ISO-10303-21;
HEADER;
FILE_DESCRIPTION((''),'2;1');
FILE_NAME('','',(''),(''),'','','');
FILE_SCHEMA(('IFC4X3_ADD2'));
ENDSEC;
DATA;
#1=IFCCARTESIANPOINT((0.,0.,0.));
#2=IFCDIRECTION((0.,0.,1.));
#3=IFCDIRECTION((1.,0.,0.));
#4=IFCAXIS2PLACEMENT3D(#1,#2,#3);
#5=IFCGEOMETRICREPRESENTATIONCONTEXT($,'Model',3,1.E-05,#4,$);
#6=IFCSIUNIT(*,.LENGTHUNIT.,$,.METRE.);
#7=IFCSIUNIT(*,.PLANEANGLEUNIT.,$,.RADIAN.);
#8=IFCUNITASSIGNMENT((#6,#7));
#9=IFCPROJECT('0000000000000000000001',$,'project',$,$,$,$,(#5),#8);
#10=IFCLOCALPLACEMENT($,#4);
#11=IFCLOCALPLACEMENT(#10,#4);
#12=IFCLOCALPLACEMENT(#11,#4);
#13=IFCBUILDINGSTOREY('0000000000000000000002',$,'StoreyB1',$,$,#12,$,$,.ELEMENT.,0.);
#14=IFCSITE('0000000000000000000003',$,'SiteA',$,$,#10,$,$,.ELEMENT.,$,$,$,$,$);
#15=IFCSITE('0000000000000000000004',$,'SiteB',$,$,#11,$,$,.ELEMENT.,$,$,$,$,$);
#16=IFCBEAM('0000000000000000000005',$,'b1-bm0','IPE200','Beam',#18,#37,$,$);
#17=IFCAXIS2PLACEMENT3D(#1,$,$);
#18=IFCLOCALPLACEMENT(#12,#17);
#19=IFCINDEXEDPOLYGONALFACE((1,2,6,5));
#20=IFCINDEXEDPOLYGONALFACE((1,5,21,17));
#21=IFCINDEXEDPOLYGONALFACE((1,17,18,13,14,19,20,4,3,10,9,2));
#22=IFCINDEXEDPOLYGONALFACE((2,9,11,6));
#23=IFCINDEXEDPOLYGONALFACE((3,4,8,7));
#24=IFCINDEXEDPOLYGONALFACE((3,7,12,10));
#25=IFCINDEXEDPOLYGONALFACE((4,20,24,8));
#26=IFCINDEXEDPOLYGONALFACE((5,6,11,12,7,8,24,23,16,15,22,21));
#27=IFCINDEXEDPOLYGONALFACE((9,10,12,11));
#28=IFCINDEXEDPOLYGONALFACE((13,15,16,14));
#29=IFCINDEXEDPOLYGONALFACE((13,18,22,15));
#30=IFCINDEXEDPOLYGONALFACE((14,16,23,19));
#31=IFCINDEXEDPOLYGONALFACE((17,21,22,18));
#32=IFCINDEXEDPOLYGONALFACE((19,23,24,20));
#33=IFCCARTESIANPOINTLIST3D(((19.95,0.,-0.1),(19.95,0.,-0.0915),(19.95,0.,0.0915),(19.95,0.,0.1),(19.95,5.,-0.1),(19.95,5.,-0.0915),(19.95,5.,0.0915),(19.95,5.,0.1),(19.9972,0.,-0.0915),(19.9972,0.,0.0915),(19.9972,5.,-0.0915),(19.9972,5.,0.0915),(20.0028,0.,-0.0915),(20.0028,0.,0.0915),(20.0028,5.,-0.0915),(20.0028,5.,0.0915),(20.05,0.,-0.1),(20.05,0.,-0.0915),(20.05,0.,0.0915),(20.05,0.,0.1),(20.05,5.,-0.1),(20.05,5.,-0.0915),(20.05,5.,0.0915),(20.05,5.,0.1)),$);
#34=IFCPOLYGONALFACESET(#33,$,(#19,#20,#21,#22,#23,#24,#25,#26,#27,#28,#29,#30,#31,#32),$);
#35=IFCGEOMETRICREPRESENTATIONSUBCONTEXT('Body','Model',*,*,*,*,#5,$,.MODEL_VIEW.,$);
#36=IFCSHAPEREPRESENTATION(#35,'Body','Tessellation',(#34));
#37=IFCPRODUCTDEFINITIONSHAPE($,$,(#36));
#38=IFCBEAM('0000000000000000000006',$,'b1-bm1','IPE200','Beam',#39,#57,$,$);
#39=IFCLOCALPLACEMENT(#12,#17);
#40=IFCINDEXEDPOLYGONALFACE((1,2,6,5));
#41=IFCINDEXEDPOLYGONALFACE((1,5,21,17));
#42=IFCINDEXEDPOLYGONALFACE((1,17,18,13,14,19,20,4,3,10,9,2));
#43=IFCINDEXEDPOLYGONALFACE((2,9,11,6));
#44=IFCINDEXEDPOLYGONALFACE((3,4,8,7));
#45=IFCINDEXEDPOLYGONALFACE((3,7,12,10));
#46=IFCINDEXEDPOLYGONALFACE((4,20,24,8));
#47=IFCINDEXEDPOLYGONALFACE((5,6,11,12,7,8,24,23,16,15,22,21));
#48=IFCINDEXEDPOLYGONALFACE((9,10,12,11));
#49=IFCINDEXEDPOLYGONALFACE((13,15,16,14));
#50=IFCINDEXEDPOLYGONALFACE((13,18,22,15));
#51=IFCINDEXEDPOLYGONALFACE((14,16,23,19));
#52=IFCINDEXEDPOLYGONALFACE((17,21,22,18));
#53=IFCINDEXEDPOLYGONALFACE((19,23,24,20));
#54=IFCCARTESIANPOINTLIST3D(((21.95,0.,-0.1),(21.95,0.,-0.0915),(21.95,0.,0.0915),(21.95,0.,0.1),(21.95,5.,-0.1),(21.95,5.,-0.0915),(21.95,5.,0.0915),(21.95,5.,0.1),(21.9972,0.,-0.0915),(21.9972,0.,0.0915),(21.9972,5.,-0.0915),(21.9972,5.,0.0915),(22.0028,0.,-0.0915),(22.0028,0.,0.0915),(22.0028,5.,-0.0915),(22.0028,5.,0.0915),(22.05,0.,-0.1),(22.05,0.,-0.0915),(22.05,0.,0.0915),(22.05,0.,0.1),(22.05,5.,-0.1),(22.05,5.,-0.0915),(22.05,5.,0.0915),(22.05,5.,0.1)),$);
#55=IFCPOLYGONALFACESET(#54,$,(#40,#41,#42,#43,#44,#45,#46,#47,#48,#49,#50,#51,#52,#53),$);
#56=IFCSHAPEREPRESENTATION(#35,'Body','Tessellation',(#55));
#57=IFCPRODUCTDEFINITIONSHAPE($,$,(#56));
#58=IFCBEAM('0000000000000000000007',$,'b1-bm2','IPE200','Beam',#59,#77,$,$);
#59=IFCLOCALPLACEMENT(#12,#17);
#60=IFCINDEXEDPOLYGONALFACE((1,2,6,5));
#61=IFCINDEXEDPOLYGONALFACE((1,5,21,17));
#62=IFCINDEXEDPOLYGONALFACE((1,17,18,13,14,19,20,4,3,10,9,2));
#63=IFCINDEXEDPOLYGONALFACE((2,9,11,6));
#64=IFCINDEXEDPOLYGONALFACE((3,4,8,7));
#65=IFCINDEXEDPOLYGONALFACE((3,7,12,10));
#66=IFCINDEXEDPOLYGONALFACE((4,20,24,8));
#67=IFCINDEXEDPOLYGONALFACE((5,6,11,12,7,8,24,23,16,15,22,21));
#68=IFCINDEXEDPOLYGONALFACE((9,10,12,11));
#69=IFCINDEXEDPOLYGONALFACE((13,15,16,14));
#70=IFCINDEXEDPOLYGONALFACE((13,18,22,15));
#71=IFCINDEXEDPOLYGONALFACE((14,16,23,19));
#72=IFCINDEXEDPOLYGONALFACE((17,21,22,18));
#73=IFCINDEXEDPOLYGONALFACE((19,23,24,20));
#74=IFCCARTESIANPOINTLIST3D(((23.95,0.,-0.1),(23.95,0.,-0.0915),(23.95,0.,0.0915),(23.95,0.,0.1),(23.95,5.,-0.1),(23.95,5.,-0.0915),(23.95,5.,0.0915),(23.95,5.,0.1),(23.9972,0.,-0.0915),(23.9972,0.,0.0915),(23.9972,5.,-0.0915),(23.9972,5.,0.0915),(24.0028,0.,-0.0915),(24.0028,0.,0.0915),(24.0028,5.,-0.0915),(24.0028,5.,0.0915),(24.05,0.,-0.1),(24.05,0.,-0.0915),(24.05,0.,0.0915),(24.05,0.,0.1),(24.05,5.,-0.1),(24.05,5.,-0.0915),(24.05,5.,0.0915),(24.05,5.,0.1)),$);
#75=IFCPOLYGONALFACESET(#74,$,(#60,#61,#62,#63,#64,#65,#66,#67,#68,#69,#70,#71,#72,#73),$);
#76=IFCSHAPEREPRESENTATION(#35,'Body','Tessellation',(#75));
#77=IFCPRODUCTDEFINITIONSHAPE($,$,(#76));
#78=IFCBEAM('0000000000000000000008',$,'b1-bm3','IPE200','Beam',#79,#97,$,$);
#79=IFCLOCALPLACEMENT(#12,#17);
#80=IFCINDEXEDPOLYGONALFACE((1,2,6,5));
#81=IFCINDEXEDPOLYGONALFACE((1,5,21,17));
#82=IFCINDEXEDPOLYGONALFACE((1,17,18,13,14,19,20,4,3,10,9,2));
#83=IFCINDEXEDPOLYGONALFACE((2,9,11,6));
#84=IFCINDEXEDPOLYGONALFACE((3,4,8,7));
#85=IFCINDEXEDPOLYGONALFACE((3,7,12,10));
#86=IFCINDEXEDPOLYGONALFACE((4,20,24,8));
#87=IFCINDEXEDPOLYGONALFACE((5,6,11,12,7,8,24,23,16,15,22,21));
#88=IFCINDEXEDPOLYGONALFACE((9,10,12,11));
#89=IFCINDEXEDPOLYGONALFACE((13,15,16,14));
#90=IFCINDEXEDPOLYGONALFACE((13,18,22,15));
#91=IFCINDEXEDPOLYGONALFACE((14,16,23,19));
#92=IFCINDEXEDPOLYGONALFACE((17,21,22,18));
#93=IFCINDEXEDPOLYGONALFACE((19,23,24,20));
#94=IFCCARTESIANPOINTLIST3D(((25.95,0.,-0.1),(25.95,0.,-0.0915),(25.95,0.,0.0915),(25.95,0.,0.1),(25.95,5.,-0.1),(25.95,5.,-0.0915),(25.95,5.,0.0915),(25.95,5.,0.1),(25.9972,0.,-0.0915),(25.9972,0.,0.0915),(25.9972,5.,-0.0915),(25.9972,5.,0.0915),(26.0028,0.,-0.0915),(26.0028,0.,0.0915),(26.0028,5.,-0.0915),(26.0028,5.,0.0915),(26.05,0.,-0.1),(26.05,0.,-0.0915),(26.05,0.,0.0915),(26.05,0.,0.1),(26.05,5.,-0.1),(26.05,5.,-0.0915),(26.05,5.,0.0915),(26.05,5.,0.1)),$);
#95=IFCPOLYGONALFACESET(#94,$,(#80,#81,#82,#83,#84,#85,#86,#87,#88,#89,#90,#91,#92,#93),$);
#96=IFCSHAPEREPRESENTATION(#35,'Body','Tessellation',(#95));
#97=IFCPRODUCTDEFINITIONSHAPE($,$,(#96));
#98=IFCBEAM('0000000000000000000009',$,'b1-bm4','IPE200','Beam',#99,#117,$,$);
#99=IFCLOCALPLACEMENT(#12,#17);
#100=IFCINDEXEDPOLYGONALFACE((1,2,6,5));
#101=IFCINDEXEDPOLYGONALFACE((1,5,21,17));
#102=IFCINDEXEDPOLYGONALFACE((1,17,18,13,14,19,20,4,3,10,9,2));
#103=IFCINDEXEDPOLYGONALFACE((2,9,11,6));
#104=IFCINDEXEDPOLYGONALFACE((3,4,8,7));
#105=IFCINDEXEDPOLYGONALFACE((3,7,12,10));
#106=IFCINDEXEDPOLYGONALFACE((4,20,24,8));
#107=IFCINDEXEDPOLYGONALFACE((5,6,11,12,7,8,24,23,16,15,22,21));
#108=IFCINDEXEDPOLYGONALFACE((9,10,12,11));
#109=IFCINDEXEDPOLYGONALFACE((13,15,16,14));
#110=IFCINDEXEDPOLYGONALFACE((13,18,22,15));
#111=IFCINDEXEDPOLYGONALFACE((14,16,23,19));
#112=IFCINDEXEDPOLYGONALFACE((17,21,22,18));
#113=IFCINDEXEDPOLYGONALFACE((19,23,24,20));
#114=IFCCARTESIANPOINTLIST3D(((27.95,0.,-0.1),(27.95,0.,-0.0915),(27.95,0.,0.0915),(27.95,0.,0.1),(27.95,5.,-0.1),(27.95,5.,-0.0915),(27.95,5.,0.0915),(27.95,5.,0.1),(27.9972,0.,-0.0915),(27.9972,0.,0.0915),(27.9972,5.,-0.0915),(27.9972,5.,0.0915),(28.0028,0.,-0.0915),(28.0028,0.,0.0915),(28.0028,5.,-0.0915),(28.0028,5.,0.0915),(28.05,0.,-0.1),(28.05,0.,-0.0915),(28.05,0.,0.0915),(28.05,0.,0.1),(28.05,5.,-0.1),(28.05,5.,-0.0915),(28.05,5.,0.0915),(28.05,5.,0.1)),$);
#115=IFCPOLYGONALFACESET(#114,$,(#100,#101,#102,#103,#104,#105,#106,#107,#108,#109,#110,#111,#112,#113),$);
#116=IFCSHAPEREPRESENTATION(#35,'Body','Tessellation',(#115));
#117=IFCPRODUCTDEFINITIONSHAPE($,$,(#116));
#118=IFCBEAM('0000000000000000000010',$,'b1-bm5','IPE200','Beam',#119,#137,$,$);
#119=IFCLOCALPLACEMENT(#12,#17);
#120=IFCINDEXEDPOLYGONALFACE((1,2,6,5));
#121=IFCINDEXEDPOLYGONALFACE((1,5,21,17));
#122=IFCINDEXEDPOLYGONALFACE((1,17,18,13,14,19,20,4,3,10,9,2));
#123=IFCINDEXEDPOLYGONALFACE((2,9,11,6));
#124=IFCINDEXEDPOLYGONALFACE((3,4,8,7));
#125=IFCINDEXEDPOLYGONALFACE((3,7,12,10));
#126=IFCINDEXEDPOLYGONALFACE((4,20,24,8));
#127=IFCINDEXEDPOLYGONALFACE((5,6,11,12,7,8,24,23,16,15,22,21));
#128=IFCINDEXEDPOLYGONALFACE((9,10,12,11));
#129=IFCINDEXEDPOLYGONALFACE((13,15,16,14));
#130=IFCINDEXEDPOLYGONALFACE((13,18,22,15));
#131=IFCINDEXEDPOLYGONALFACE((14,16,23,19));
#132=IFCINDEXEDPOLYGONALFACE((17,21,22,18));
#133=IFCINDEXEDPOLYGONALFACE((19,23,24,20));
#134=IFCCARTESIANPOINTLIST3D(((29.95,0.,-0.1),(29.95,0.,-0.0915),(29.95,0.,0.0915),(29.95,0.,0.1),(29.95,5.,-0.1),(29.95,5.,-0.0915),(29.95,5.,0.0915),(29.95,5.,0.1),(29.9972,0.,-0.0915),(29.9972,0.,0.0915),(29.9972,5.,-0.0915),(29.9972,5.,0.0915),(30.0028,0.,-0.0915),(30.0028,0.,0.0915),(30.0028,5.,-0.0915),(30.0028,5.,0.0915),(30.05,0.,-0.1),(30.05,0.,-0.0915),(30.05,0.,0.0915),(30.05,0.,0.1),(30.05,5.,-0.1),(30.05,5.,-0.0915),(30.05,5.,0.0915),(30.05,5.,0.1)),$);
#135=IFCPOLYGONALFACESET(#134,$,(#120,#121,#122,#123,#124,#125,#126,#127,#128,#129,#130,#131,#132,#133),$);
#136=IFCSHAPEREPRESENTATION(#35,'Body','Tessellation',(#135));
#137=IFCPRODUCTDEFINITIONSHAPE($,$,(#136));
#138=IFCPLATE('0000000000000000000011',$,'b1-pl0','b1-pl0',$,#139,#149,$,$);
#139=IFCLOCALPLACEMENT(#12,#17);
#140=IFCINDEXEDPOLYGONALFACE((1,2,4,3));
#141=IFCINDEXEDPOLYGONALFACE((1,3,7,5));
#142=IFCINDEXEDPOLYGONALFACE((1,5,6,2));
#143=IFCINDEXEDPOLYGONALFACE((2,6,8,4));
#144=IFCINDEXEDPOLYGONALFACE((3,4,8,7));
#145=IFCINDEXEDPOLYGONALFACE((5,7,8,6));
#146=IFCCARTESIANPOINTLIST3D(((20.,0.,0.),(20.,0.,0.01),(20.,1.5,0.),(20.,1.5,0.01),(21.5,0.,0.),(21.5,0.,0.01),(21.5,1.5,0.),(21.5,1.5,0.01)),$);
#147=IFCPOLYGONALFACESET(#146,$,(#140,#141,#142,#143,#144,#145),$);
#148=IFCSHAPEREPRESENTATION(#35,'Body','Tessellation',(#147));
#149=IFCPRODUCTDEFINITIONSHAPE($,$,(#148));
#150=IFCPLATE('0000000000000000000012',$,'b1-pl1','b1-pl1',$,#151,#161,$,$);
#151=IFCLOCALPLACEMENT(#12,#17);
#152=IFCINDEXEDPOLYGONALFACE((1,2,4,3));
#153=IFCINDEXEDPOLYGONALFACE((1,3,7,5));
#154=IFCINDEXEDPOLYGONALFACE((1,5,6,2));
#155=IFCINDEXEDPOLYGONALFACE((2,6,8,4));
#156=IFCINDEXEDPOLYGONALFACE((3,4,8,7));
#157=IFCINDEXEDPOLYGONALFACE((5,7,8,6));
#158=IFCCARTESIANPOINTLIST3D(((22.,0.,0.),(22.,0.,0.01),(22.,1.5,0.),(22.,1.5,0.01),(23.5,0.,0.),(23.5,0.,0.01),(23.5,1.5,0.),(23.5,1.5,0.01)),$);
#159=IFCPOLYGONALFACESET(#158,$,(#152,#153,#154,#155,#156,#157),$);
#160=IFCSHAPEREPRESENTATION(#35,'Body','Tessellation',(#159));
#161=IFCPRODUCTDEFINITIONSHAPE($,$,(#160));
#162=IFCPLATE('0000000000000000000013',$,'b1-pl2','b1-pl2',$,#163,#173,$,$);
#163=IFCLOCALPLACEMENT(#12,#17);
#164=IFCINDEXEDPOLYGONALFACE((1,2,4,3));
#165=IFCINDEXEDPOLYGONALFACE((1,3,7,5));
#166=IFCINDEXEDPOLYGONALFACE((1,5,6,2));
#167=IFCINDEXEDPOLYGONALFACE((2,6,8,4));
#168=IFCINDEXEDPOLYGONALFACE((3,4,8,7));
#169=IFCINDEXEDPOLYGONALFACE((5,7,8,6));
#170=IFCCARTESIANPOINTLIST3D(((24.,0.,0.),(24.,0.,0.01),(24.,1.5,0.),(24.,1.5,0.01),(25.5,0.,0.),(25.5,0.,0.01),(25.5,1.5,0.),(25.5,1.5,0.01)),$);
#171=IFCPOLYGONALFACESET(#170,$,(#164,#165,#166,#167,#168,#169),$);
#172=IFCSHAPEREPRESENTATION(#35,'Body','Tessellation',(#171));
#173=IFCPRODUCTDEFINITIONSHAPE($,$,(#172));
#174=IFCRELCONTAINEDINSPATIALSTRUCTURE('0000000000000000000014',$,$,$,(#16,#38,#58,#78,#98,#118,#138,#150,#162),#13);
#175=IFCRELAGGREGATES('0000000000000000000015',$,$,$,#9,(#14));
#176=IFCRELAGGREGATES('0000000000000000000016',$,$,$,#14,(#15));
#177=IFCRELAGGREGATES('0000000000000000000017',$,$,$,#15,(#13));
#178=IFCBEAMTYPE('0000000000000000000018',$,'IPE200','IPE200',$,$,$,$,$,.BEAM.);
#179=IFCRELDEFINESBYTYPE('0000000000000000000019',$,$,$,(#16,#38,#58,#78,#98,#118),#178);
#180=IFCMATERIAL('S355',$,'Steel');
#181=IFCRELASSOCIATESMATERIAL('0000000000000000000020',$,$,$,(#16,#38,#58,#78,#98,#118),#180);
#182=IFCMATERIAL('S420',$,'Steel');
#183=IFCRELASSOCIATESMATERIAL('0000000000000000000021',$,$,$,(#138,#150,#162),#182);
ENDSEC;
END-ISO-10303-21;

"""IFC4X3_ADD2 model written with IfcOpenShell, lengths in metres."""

from ifc_helpers import new_model, si_unit, frame, origin_with_axes, place, context, subcontext, project, spatial, line, indexed_curve, i_section, outline, extrude, material, material_profile, profile_set, profile_usage, type_object, element, save


model = new_model("IFC4X3_ADD2")

# Units and contexts
model_context = context("Model", 3, precision=1e-05, world=origin_with_axes())
body_context = subcontext(model_context, "Body", "Model", "MODEL_VIEW")
ifc_project = project(units=[si_unit("LENGTHUNIT", "METRE"), si_unit("PLANEANGLEUNIT", "RADIAN")], contexts=[model_context])

# Sites, storey
site_1_placement = place(None, origin_with_axes())
site_1 = spatial("IfcSite", under=ifc_project, at=site_1_placement, Name="SiteA", CompositionType="ELEMENT")
site_2_placement = place(site_1_placement, origin_with_axes())
site_2 = spatial("IfcSite", under=site_1, at=site_2_placement, Name="SiteB", CompositionType="ELEMENT")
storey_placement = place(site_2_placement, origin_with_axes())
storey = spatial("IfcBuildingStorey", under=site_2, at=storey_placement, Name="StoreyB1", CompositionType="ELEMENT", Elevation=0.0)

# Beams
ifc_material_1 = material(Name="S355", Category="Steel")
ifc_material_profile_1 = material_profile(ifc_material_1, i_section(OverallWidth=0.1, OverallDepth=0.2, WebThickness=0.0056, FlangeThickness=0.0085), Name="IPE200", Category="LoadBearing")
ifc_profile_set_1 = profile_set([ifc_material_profile_1], Name="IPE200")
ifc_profile_usage_1 = profile_usage(ifc_profile_set_1, cardinal=5)
beam_type = type_object("IfcBeamType", Name="IPE200", Description="IPE200", PredefinedType="BEAM")
placement_1 = place(storey_placement, origin_with_axes())
beam_1_placement = place(placement_1, origin_with_axes())
element("IfcBeam", 1, at=beam_1_placement, inside=storey, type_object=beam_type, material=ifc_profile_usage_1, Name="b1-bm0", Description="IPE200", ObjectType="Beam", context=body_context, shape_type="SolidModel", body=[
    extrude(i_section(OverallWidth=0.1, OverallDepth=0.2, WebThickness=0.0056, FlangeThickness=0.0085), frame((20.0, 0.0, 0.0), z_axis=(0.0, 1.0, 0.0), x_axis=(-1.0, 0.0, 0.0)), (0.0, 0.0, 1.0), 5.0),
])
ifc_material_profile_2 = material_profile(ifc_material_1, i_section(OverallWidth=0.1, OverallDepth=0.2, WebThickness=0.0056, FlangeThickness=0.0085), Name="IPE200", Category="LoadBearing")
ifc_profile_set_2 = profile_set([ifc_material_profile_2], Name="IPE200")
ifc_profile_usage_2 = profile_usage(ifc_profile_set_2, cardinal=5)
placement_2 = place(storey_placement, origin_with_axes())
beam_2_placement = place(placement_2, origin_with_axes())
element("IfcBeam", 2, at=beam_2_placement, inside=storey, type_object=beam_type, material=ifc_profile_usage_2, Name="b1-bm1", Description="IPE200", ObjectType="Beam", context=body_context, shape_type="SolidModel", body=[
    extrude(i_section(OverallWidth=0.1, OverallDepth=0.2, WebThickness=0.0056, FlangeThickness=0.0085), frame((22.0, 0.0, 0.0), z_axis=(0.0, 1.0, 0.0), x_axis=(-1.0, 0.0, 0.0)), (0.0, 0.0, 1.0), 5.0),
])
ifc_material_profile_3 = material_profile(ifc_material_1, i_section(OverallWidth=0.1, OverallDepth=0.2, WebThickness=0.0056, FlangeThickness=0.0085), Name="IPE200", Category="LoadBearing")
ifc_profile_set_3 = profile_set([ifc_material_profile_3], Name="IPE200")
ifc_profile_usage_3 = profile_usage(ifc_profile_set_3, cardinal=5)
placement_3 = place(storey_placement, origin_with_axes())
beam_3_placement = place(placement_3, origin_with_axes())
element("IfcBeam", 3, at=beam_3_placement, inside=storey, type_object=beam_type, material=ifc_profile_usage_3, Name="b1-bm2", Description="IPE200", ObjectType="Beam", context=body_context, shape_type="SolidModel", body=[
    extrude(i_section(OverallWidth=0.1, OverallDepth=0.2, WebThickness=0.0056, FlangeThickness=0.0085), frame((24.0, 0.0, 0.0), z_axis=(0.0, 1.0, 0.0), x_axis=(-1.0, 0.0, 0.0)), (0.0, 0.0, 1.0), 5.0),
])
ifc_material_profile_4 = material_profile(ifc_material_1, i_section(OverallWidth=0.1, OverallDepth=0.2, WebThickness=0.0056, FlangeThickness=0.0085), Name="IPE200", Category="LoadBearing")
ifc_profile_set_4 = profile_set([ifc_material_profile_4], Name="IPE200")
ifc_profile_usage_4 = profile_usage(ifc_profile_set_4, cardinal=5)
placement_4 = place(storey_placement, origin_with_axes())
beam_4_placement = place(placement_4, origin_with_axes())
element("IfcBeam", 4, at=beam_4_placement, inside=storey, type_object=beam_type, material=ifc_profile_usage_4, Name="b1-bm3", Description="IPE200", ObjectType="Beam", context=body_context, shape_type="SolidModel", body=[
    extrude(i_section(OverallWidth=0.1, OverallDepth=0.2, WebThickness=0.0056, FlangeThickness=0.0085), frame((26.0, 0.0, 0.0), z_axis=(0.0, 1.0, 0.0), x_axis=(-1.0, 0.0, 0.0)), (0.0, 0.0, 1.0), 5.0),
])
ifc_material_profile_5 = material_profile(ifc_material_1, i_section(OverallWidth=0.1, OverallDepth=0.2, WebThickness=0.0056, FlangeThickness=0.0085), Name="IPE200", Category="LoadBearing")
ifc_profile_set_5 = profile_set([ifc_material_profile_5], Name="IPE200")
ifc_profile_usage_5 = profile_usage(ifc_profile_set_5, cardinal=5)
placement_5 = place(storey_placement, origin_with_axes())
beam_5_placement = place(placement_5, origin_with_axes())
element("IfcBeam", 5, at=beam_5_placement, inside=storey, type_object=beam_type, material=ifc_profile_usage_5, Name="b1-bm4", Description="IPE200", ObjectType="Beam", context=body_context, shape_type="SolidModel", body=[
    extrude(i_section(OverallWidth=0.1, OverallDepth=0.2, WebThickness=0.0056, FlangeThickness=0.0085), frame((28.0, 0.0, 0.0), z_axis=(0.0, 1.0, 0.0), x_axis=(-1.0, 0.0, 0.0)), (0.0, 0.0, 1.0), 5.0),
])
ifc_material_profile_6 = material_profile(ifc_material_1, i_section(OverallWidth=0.1, OverallDepth=0.2, WebThickness=0.0056, FlangeThickness=0.0085), Name="IPE200", Category="LoadBearing")
ifc_profile_set_6 = profile_set([ifc_material_profile_6], Name="IPE200")
ifc_profile_usage_6 = profile_usage(ifc_profile_set_6, cardinal=5)
placement_6 = place(storey_placement, origin_with_axes())
beam_6_placement = place(placement_6, origin_with_axes())
element("IfcBeam", 6, at=beam_6_placement, inside=storey, type_object=beam_type, material=ifc_profile_usage_6, Name="b1-bm5", Description="IPE200", ObjectType="Beam", context=body_context, shape_type="SolidModel", body=[
    extrude(i_section(OverallWidth=0.1, OverallDepth=0.2, WebThickness=0.0056, FlangeThickness=0.0085), frame((30.0, 0.0, 0.0), z_axis=(0.0, 1.0, 0.0), x_axis=(-1.0, 0.0, 0.0)), (0.0, 0.0, 1.0), 5.0),
])

# Plates
ifc_material_2 = material(Name="S420", Category="Steel")
plate_1_placement = place(None, origin_with_axes())
element("IfcPlate", 7, at=plate_1_placement, inside=storey, material=ifc_material_2, Name="b1-pl0", Description="b1-pl0", context=body_context, shape_type="SolidModel", body=[
    extrude(outline(indexed_curve([(20.0, 0.0), (20.0, 1.5), (21.5, 0.0), (21.5, 1.5)], segments=[line(3, 1), line(1, 2), line(2, 4), line(4, 3)])), origin_with_axes(), (0.0, 0.0, 1.0), 0.01),
])
plate_2_placement = place(None, origin_with_axes())
element("IfcPlate", 8, at=plate_2_placement, inside=storey, material=ifc_material_2, Name="b1-pl1", Description="b1-pl1", context=body_context, shape_type="SolidModel", body=[
    extrude(outline(indexed_curve([(22.0, 0.0), (22.0, 1.5), (23.5, 0.0), (23.5, 1.5)], segments=[line(3, 1), line(1, 2), line(2, 4), line(4, 3)])), origin_with_axes(), (0.0, 0.0, 1.0), 0.01),
])
plate_3_placement = place(None, origin_with_axes())
element("IfcPlate", 9, at=plate_3_placement, inside=storey, material=ifc_material_2, Name="b1-pl2", Description="b1-pl2", context=body_context, shape_type="SolidModel", body=[
    extrude(outline(indexed_curve([(24.0, 0.0), (24.0, 1.5), (25.5, 0.0), (25.5, 1.5)], segments=[line(3, 1), line(1, 2), line(2, 4), line(4, 3)])), origin_with_axes(), (0.0, 0.0, 1.0), 0.01),
])

save(model, "model.ifc")
